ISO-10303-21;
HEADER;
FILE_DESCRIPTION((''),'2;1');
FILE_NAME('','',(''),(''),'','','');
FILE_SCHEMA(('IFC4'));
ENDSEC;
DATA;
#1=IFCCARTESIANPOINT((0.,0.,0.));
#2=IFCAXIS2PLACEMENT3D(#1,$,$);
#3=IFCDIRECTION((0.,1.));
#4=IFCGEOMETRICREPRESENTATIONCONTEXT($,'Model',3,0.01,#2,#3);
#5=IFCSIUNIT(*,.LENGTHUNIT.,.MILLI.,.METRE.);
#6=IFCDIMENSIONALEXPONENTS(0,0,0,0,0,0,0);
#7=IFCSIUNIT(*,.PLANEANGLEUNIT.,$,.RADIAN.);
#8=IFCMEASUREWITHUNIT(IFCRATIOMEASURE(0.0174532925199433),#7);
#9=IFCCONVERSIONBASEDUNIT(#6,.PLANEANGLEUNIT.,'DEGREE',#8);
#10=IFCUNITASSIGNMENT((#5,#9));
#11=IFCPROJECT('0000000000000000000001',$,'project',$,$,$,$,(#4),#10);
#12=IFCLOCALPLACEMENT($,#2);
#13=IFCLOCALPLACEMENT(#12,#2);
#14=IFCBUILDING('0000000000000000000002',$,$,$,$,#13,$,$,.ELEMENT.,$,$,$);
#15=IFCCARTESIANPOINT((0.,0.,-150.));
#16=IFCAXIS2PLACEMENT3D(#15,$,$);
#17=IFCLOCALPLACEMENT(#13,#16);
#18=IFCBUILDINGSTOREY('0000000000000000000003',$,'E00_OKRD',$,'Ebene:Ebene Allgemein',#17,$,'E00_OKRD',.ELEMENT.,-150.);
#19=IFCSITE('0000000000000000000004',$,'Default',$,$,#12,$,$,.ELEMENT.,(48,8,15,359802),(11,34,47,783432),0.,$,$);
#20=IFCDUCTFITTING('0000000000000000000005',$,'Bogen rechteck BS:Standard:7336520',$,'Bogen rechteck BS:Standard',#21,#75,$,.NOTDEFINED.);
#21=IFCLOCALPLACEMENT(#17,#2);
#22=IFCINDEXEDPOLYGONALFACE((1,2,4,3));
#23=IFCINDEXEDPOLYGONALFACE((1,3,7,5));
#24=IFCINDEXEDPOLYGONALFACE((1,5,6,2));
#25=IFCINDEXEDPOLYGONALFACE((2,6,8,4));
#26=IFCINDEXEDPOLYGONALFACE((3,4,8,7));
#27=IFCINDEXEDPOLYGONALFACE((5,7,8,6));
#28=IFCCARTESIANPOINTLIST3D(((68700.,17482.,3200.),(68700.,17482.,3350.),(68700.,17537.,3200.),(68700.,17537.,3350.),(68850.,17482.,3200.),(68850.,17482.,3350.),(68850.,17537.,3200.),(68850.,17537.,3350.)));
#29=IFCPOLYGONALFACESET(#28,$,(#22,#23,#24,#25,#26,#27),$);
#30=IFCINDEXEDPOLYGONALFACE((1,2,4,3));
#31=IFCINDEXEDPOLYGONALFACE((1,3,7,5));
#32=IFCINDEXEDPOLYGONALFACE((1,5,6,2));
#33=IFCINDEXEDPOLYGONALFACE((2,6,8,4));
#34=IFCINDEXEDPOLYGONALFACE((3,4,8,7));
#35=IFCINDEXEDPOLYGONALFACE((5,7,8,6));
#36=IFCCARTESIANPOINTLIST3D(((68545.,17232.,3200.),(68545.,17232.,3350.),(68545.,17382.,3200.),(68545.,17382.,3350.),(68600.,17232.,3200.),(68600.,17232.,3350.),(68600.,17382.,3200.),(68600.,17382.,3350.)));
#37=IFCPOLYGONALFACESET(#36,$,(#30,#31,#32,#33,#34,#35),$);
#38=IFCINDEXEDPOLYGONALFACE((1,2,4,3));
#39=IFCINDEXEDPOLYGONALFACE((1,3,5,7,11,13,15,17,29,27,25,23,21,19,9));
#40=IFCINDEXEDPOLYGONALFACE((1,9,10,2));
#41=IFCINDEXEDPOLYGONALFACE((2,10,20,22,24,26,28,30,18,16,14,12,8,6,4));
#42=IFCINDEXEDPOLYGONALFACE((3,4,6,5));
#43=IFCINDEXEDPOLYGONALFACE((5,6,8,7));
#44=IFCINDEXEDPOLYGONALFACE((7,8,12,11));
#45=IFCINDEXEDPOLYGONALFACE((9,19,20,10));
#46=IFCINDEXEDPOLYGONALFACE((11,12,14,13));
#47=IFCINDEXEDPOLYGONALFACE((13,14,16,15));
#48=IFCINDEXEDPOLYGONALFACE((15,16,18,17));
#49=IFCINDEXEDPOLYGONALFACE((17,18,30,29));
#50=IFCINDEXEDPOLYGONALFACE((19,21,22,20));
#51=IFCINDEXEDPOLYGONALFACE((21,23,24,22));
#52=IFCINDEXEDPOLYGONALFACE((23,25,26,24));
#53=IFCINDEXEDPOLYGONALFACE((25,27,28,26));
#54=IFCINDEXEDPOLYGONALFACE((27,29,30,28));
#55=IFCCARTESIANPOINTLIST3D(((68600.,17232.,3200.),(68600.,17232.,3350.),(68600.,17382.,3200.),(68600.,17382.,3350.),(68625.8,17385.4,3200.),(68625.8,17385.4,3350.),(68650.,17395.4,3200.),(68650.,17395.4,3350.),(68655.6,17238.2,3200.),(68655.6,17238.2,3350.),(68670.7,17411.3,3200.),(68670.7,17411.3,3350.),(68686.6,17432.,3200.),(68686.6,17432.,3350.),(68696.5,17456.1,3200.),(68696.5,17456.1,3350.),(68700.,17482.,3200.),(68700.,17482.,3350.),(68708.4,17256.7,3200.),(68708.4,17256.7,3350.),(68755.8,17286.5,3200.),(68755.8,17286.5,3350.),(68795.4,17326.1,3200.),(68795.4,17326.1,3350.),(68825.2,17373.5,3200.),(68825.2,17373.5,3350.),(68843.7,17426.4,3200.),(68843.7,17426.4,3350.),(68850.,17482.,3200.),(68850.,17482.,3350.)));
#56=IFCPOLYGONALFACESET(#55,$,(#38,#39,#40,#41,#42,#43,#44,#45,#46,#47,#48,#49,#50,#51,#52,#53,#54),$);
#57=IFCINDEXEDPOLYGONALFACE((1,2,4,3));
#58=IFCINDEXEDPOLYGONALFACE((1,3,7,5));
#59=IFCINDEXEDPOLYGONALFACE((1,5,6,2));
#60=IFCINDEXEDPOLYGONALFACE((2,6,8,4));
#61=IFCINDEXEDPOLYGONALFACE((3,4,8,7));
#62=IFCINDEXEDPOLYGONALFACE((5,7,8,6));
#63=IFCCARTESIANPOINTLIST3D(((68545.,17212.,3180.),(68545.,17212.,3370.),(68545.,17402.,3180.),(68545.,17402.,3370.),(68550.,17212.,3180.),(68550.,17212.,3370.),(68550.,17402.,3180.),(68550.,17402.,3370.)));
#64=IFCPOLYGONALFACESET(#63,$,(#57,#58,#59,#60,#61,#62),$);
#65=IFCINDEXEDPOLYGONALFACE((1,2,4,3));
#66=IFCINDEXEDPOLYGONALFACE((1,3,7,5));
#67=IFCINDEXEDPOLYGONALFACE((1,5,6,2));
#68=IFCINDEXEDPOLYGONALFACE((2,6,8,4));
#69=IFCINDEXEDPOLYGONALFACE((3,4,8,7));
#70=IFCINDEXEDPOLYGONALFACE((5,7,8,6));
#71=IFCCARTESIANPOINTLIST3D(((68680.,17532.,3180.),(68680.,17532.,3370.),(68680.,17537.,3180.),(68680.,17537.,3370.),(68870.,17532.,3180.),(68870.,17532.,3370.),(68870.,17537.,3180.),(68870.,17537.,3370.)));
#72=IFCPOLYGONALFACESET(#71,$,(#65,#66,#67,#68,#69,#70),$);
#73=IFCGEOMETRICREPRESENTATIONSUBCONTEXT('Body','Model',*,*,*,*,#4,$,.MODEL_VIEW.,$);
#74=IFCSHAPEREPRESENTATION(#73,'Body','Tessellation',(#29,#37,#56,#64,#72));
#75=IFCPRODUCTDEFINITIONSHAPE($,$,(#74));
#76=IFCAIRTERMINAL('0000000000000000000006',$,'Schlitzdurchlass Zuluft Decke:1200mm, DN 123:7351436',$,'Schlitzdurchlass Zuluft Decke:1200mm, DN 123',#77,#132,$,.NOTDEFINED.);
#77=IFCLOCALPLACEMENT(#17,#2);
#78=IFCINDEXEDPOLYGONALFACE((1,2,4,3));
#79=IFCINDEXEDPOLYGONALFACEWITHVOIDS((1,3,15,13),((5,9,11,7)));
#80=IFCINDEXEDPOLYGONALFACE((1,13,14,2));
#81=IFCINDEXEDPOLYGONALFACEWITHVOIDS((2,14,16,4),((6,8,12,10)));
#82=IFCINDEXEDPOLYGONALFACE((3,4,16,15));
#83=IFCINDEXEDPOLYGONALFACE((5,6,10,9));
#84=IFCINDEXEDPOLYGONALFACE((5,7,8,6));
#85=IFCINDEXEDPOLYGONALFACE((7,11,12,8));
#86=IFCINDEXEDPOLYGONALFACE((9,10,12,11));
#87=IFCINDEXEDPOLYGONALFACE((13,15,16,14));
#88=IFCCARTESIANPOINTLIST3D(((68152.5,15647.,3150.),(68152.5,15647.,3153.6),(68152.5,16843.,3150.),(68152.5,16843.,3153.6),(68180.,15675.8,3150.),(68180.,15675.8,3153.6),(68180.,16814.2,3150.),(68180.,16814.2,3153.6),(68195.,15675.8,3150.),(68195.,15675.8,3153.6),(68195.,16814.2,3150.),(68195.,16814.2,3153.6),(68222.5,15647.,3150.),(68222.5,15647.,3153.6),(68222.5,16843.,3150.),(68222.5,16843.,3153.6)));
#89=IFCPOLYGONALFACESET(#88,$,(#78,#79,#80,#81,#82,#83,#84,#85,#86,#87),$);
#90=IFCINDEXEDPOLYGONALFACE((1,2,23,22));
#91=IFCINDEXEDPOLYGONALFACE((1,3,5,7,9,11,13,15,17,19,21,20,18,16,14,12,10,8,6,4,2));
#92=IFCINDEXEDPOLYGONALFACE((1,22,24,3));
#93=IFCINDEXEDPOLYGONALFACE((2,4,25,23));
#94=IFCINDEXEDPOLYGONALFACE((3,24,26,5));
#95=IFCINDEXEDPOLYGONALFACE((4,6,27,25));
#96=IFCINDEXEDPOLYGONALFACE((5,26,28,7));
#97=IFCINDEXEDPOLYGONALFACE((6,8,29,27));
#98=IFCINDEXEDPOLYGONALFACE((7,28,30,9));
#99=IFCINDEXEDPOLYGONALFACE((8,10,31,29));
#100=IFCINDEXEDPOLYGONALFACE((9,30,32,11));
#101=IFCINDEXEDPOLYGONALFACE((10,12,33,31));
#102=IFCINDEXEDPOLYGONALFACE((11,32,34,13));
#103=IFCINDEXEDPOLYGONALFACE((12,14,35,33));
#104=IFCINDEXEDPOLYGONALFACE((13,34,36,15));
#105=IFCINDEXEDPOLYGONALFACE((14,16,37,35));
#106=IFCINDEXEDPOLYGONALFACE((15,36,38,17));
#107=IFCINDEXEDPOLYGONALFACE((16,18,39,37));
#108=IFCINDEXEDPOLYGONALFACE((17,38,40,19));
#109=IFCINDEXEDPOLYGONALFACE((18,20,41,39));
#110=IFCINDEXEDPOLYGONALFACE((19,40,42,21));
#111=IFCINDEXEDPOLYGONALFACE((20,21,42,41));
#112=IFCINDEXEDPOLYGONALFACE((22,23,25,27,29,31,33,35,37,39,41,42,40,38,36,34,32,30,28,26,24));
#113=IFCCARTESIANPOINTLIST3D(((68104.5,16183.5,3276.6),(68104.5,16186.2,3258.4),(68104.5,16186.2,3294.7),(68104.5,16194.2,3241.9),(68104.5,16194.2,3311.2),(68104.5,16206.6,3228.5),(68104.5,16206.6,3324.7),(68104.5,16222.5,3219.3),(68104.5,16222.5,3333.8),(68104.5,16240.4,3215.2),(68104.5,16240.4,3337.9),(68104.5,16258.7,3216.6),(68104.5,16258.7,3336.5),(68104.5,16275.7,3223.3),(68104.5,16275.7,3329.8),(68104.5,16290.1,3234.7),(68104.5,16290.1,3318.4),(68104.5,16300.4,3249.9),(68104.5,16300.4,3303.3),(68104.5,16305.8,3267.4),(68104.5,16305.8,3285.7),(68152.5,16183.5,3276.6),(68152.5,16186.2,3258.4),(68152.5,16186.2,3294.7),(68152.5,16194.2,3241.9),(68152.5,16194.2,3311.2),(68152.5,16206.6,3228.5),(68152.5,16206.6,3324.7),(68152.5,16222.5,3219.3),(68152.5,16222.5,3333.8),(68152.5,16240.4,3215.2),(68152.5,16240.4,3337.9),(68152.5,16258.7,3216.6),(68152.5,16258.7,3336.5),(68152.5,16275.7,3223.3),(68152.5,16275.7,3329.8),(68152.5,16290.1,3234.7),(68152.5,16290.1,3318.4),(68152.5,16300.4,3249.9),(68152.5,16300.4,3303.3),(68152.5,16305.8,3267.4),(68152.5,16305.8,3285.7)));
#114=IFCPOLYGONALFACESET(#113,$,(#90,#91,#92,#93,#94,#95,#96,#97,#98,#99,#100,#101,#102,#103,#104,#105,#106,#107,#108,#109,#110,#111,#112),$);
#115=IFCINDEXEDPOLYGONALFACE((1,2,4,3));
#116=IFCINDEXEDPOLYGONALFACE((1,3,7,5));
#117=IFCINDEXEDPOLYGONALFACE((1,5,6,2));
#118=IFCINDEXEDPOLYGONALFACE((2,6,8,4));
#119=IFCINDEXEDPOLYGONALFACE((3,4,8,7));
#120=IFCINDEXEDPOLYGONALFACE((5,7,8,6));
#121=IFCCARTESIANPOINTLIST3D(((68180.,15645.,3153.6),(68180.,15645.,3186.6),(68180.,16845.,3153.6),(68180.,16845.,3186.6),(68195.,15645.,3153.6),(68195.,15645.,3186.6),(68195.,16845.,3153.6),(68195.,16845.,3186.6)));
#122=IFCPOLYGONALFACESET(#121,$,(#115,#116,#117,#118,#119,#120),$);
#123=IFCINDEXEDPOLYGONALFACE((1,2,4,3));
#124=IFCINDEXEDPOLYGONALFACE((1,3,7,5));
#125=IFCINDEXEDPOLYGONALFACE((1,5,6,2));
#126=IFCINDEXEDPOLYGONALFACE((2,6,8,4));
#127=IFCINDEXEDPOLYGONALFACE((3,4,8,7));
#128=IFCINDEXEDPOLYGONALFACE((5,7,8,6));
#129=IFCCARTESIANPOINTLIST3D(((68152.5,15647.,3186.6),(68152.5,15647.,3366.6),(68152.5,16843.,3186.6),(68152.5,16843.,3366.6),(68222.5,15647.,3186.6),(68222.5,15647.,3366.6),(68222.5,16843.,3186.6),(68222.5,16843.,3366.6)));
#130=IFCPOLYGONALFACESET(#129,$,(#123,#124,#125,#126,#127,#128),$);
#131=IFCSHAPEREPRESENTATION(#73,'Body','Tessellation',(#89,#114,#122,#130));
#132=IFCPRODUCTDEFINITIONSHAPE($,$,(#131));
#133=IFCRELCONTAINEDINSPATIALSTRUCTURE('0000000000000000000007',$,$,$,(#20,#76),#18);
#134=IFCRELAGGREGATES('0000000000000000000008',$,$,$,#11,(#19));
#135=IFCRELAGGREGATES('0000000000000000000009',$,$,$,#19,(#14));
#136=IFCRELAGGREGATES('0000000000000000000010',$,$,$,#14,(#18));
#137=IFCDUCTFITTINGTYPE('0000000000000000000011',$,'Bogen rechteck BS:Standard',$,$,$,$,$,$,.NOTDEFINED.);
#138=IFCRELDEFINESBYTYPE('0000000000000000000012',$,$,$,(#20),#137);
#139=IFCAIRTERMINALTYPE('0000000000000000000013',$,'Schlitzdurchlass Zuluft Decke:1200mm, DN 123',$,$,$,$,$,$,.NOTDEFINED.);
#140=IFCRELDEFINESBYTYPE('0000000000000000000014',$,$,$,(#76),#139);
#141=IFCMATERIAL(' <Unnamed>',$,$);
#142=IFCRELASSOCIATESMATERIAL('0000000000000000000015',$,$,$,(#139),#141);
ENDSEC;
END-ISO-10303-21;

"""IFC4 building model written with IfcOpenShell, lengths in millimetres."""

from ifc_helpers import new_model, entity, si_unit, converted_unit, direction, frame, frame_2d, origin, origin_2d_with_axis, place, context, subcontext, project, spatial, polyline, circle_curve, parameter, trimmed, segment, composite_curve, rectangle, circle, outline, extrude, source, transform, mapped, material, type_object, type_shapes, element, save


model = new_model("IFC4")

# Units and contexts
model_context = context("Model", 3, precision=0.01, world=origin(), true_north=direction((0.0, 1.0)))
body_context = subcontext(model_context, "Body", "Model", "MODEL_VIEW")
ifc_project = project(units=[si_unit("LENGTHUNIT", "METRE", prefix="MILLI"), converted_unit("PLANEANGLEUNIT", "DEGREE", entity("IfcRatioMeasure", 0.0174532925199433), si_unit("PLANEANGLEUNIT", "RADIAN"), dimensions=[0, 0, 0, 0, 0, 0, 0])], contexts=[model_context])

# Site, building, storey
site_placement = place(None, origin())
site = spatial("IfcSite", under=ifc_project, at=site_placement, Name="Default", CompositionType="ELEMENT", RefLatitude=(48, 8, 15, 359802), RefLongitude=(11, 34, 47, 783432), RefElevation=0.0)
building_placement = place(site_placement, origin())
building = spatial("IfcBuilding", under=site, at=building_placement, CompositionType="ELEMENT")
storey_placement = place(building_placement, frame((0.0, 0.0, -150.0)))
storey = spatial("IfcBuildingStorey", under=building, at=storey_placement, Name="E00_OKRD", ObjectType="Ebene:Ebene Allgemein", LongName="E00_OKRD", CompositionType="ELEMENT", Elevation=-150.0)

# Shared definitions
ifc_material_1 = material(Name=" <Unnamed>")

# Duct fitting
duct_fitting_type_1 = type_object("IfcDuctFittingType", Name="Bogen rechteck BS:Standard", PredefinedType="NOTDEFINED")
shared_shape_1 = source(origin(), body_context, "Body", "SweptSolid", [
    extrude(rectangle(XDim=55.0, YDim=150.0, at=origin_2d_with_axis()), frame((0.0, 202.5, -75.0), z_axis=(0.0, 0.0, 1.0), x_axis=(0.0, 1.0, 0.0)), (0.0, 0.0, 1.0), 150.0),
    extrude(rectangle(XDim=150.0, YDim=55.0, at=frame_2d((0.0, 0.0), x_axis=(1.0, 0.0))), frame((-202.5, 0.0, -75.0), z_axis=(0.0, 0.0, 1.0), x_axis=(0.0, -1.0, 0.0)), (0.0, 0.0, 1.0), 150.0),
    extrude(outline(composite_curve([segment(polyline([(-162.5, -87.5), (-12.5, -87.5)]), True, "CONTINUOUS"), segment(trimmed(circle_curve(frame_2d((87.5, -87.5), x_axis=(0.0, 1.0)), 100.0), [parameter(0.0)], [parameter(90.0)], True, "PARAMETER"), False, "CONTINUOUS"), segment(polyline([(87.5, 12.5), (87.5, 162.5)]), True, "CONTINUOUS"), segment(trimmed(circle_curve(frame_2d((87.5, -87.5), x_axis=(0.0, 1.0)), 250.0), [parameter(0.0)], [parameter(90.0)], True, "PARAMETER"), True, "CONTINUOUS")], self_intersect=False)), frame((-87.5, 87.5, -75.0), z_axis=(0.0, 0.0, 1.0), x_axis=(-1.0, 0.0, 0.0)), (0.0, 0.0, 1.0), 150.0),
    extrude(rectangle(XDim=5.0, YDim=190.0, at=frame_2d((0.0, 0.0), x_axis=(1.0, 0.0))), frame((-227.5, 0.0, -95.0)), (0.0, 0.0, 1.0), 190.0),
    extrude(rectangle(XDim=5.0, YDim=190.0, at=frame_2d((0.0, 0.0), x_axis=(1.0, 0.0))), frame((0.0, 227.5, -95.0), z_axis=(0.0, 0.0, 1.0), x_axis=(0.0, 1.0, 0.0)), (0.0, 0.0, 1.0), 190.0),
])
type_shapes(duct_fitting_type_1, [shared_shape_1])
duct_fitting_1_placement = place(storey_placement, frame((68775.0, 17307.0, 3275.0)))
element("IfcDuctFitting", 1, at=duct_fitting_1_placement, inside=storey, type_object=duct_fitting_type_1, Name="Bogen rechteck BS:Standard:7336520", ObjectType="Bogen rechteck BS:Standard", PredefinedType="NOTDEFINED", context=body_context, shape_type="MappedRepresentation", body=[
    mapped(shared_shape_1, transform((0.0, 0.0, 0.0), scale=1.0)),
])

# Air terminal
air_terminal_type_1 = type_object("IfcAirTerminalType", Name="Schlitzdurchlass Zuluft Decke:1200mm, DN 123", PredefinedType="NOTDEFINED", material=ifc_material_1)
shared_shape_2 = source(origin(), body_context, "Body", "SweptSolid", [
    extrude(outline(polyline([(-598.0, -35.0), (598.0, -35.0), (598.0, 35.0), (-598.0, 35.0), (-598.0, -35.0)]), holes=[polyline([(-569.2, -7.5), (-569.2, 7.5), (569.2, 7.5), (569.2, -7.5), (-569.2, -7.5)])]), frame((600.0, 35.0, 0.0), z_axis=(0.0, 0.0, 1.0), x_axis=(-1.0, 0.0, 0.0)), (0.0, 0.0, 1.0), 3.6),
    extrude(circle(Radius=61.5, at=frame_2d((0.0, 0.0), x_axis=(1.0, 0.0))), frame((600.0, 70.0, 126.6), z_axis=(0.0, 1.0, 0.0), x_axis=(-1.0, 0.0, 0.0)), (0.0, 0.0, 1.0), 48.0),
    extrude(rectangle(XDim=1200.0, YDim=15.0, at=origin_2d_with_axis()), frame((600.0, 35.0, 3.6), z_axis=(0.0, 0.0, 1.0), x_axis=(-1.0, 0.0, 0.0)), (0.0, 0.0, 1.0), 33.0),
    extrude(rectangle(XDim=1196.0, YDim=70.0, at=origin_2d_with_axis()), frame((600.0, 35.0, 36.6), z_axis=(0.0, 0.0, 1.0), x_axis=(-1.0, 0.0, 0.0)), (0.0, 0.0, 1.0), 180.0),
])
type_shapes(air_terminal_type_1, [shared_shape_2])
air_terminal_1_placement = place(storey_placement, frame((68222.5, 15645.0, 3150.0), z_axis=(0.0, 0.0, 1.0), x_axis=(0.0, 1.0, 0.0)))
element("IfcAirTerminal", 2, at=air_terminal_1_placement, inside=storey, type_object=air_terminal_type_1, Name="Schlitzdurchlass Zuluft Decke:1200mm, DN 123:7351436", ObjectType="Schlitzdurchlass Zuluft Decke:1200mm, DN 123", PredefinedType="NOTDEFINED", context=body_context, shape_type="MappedRepresentation", body=[
    mapped(shared_shape_2, transform((0.0, 0.0, 0.0), scale=1.0)),
])

save(model, "model.ifc")
